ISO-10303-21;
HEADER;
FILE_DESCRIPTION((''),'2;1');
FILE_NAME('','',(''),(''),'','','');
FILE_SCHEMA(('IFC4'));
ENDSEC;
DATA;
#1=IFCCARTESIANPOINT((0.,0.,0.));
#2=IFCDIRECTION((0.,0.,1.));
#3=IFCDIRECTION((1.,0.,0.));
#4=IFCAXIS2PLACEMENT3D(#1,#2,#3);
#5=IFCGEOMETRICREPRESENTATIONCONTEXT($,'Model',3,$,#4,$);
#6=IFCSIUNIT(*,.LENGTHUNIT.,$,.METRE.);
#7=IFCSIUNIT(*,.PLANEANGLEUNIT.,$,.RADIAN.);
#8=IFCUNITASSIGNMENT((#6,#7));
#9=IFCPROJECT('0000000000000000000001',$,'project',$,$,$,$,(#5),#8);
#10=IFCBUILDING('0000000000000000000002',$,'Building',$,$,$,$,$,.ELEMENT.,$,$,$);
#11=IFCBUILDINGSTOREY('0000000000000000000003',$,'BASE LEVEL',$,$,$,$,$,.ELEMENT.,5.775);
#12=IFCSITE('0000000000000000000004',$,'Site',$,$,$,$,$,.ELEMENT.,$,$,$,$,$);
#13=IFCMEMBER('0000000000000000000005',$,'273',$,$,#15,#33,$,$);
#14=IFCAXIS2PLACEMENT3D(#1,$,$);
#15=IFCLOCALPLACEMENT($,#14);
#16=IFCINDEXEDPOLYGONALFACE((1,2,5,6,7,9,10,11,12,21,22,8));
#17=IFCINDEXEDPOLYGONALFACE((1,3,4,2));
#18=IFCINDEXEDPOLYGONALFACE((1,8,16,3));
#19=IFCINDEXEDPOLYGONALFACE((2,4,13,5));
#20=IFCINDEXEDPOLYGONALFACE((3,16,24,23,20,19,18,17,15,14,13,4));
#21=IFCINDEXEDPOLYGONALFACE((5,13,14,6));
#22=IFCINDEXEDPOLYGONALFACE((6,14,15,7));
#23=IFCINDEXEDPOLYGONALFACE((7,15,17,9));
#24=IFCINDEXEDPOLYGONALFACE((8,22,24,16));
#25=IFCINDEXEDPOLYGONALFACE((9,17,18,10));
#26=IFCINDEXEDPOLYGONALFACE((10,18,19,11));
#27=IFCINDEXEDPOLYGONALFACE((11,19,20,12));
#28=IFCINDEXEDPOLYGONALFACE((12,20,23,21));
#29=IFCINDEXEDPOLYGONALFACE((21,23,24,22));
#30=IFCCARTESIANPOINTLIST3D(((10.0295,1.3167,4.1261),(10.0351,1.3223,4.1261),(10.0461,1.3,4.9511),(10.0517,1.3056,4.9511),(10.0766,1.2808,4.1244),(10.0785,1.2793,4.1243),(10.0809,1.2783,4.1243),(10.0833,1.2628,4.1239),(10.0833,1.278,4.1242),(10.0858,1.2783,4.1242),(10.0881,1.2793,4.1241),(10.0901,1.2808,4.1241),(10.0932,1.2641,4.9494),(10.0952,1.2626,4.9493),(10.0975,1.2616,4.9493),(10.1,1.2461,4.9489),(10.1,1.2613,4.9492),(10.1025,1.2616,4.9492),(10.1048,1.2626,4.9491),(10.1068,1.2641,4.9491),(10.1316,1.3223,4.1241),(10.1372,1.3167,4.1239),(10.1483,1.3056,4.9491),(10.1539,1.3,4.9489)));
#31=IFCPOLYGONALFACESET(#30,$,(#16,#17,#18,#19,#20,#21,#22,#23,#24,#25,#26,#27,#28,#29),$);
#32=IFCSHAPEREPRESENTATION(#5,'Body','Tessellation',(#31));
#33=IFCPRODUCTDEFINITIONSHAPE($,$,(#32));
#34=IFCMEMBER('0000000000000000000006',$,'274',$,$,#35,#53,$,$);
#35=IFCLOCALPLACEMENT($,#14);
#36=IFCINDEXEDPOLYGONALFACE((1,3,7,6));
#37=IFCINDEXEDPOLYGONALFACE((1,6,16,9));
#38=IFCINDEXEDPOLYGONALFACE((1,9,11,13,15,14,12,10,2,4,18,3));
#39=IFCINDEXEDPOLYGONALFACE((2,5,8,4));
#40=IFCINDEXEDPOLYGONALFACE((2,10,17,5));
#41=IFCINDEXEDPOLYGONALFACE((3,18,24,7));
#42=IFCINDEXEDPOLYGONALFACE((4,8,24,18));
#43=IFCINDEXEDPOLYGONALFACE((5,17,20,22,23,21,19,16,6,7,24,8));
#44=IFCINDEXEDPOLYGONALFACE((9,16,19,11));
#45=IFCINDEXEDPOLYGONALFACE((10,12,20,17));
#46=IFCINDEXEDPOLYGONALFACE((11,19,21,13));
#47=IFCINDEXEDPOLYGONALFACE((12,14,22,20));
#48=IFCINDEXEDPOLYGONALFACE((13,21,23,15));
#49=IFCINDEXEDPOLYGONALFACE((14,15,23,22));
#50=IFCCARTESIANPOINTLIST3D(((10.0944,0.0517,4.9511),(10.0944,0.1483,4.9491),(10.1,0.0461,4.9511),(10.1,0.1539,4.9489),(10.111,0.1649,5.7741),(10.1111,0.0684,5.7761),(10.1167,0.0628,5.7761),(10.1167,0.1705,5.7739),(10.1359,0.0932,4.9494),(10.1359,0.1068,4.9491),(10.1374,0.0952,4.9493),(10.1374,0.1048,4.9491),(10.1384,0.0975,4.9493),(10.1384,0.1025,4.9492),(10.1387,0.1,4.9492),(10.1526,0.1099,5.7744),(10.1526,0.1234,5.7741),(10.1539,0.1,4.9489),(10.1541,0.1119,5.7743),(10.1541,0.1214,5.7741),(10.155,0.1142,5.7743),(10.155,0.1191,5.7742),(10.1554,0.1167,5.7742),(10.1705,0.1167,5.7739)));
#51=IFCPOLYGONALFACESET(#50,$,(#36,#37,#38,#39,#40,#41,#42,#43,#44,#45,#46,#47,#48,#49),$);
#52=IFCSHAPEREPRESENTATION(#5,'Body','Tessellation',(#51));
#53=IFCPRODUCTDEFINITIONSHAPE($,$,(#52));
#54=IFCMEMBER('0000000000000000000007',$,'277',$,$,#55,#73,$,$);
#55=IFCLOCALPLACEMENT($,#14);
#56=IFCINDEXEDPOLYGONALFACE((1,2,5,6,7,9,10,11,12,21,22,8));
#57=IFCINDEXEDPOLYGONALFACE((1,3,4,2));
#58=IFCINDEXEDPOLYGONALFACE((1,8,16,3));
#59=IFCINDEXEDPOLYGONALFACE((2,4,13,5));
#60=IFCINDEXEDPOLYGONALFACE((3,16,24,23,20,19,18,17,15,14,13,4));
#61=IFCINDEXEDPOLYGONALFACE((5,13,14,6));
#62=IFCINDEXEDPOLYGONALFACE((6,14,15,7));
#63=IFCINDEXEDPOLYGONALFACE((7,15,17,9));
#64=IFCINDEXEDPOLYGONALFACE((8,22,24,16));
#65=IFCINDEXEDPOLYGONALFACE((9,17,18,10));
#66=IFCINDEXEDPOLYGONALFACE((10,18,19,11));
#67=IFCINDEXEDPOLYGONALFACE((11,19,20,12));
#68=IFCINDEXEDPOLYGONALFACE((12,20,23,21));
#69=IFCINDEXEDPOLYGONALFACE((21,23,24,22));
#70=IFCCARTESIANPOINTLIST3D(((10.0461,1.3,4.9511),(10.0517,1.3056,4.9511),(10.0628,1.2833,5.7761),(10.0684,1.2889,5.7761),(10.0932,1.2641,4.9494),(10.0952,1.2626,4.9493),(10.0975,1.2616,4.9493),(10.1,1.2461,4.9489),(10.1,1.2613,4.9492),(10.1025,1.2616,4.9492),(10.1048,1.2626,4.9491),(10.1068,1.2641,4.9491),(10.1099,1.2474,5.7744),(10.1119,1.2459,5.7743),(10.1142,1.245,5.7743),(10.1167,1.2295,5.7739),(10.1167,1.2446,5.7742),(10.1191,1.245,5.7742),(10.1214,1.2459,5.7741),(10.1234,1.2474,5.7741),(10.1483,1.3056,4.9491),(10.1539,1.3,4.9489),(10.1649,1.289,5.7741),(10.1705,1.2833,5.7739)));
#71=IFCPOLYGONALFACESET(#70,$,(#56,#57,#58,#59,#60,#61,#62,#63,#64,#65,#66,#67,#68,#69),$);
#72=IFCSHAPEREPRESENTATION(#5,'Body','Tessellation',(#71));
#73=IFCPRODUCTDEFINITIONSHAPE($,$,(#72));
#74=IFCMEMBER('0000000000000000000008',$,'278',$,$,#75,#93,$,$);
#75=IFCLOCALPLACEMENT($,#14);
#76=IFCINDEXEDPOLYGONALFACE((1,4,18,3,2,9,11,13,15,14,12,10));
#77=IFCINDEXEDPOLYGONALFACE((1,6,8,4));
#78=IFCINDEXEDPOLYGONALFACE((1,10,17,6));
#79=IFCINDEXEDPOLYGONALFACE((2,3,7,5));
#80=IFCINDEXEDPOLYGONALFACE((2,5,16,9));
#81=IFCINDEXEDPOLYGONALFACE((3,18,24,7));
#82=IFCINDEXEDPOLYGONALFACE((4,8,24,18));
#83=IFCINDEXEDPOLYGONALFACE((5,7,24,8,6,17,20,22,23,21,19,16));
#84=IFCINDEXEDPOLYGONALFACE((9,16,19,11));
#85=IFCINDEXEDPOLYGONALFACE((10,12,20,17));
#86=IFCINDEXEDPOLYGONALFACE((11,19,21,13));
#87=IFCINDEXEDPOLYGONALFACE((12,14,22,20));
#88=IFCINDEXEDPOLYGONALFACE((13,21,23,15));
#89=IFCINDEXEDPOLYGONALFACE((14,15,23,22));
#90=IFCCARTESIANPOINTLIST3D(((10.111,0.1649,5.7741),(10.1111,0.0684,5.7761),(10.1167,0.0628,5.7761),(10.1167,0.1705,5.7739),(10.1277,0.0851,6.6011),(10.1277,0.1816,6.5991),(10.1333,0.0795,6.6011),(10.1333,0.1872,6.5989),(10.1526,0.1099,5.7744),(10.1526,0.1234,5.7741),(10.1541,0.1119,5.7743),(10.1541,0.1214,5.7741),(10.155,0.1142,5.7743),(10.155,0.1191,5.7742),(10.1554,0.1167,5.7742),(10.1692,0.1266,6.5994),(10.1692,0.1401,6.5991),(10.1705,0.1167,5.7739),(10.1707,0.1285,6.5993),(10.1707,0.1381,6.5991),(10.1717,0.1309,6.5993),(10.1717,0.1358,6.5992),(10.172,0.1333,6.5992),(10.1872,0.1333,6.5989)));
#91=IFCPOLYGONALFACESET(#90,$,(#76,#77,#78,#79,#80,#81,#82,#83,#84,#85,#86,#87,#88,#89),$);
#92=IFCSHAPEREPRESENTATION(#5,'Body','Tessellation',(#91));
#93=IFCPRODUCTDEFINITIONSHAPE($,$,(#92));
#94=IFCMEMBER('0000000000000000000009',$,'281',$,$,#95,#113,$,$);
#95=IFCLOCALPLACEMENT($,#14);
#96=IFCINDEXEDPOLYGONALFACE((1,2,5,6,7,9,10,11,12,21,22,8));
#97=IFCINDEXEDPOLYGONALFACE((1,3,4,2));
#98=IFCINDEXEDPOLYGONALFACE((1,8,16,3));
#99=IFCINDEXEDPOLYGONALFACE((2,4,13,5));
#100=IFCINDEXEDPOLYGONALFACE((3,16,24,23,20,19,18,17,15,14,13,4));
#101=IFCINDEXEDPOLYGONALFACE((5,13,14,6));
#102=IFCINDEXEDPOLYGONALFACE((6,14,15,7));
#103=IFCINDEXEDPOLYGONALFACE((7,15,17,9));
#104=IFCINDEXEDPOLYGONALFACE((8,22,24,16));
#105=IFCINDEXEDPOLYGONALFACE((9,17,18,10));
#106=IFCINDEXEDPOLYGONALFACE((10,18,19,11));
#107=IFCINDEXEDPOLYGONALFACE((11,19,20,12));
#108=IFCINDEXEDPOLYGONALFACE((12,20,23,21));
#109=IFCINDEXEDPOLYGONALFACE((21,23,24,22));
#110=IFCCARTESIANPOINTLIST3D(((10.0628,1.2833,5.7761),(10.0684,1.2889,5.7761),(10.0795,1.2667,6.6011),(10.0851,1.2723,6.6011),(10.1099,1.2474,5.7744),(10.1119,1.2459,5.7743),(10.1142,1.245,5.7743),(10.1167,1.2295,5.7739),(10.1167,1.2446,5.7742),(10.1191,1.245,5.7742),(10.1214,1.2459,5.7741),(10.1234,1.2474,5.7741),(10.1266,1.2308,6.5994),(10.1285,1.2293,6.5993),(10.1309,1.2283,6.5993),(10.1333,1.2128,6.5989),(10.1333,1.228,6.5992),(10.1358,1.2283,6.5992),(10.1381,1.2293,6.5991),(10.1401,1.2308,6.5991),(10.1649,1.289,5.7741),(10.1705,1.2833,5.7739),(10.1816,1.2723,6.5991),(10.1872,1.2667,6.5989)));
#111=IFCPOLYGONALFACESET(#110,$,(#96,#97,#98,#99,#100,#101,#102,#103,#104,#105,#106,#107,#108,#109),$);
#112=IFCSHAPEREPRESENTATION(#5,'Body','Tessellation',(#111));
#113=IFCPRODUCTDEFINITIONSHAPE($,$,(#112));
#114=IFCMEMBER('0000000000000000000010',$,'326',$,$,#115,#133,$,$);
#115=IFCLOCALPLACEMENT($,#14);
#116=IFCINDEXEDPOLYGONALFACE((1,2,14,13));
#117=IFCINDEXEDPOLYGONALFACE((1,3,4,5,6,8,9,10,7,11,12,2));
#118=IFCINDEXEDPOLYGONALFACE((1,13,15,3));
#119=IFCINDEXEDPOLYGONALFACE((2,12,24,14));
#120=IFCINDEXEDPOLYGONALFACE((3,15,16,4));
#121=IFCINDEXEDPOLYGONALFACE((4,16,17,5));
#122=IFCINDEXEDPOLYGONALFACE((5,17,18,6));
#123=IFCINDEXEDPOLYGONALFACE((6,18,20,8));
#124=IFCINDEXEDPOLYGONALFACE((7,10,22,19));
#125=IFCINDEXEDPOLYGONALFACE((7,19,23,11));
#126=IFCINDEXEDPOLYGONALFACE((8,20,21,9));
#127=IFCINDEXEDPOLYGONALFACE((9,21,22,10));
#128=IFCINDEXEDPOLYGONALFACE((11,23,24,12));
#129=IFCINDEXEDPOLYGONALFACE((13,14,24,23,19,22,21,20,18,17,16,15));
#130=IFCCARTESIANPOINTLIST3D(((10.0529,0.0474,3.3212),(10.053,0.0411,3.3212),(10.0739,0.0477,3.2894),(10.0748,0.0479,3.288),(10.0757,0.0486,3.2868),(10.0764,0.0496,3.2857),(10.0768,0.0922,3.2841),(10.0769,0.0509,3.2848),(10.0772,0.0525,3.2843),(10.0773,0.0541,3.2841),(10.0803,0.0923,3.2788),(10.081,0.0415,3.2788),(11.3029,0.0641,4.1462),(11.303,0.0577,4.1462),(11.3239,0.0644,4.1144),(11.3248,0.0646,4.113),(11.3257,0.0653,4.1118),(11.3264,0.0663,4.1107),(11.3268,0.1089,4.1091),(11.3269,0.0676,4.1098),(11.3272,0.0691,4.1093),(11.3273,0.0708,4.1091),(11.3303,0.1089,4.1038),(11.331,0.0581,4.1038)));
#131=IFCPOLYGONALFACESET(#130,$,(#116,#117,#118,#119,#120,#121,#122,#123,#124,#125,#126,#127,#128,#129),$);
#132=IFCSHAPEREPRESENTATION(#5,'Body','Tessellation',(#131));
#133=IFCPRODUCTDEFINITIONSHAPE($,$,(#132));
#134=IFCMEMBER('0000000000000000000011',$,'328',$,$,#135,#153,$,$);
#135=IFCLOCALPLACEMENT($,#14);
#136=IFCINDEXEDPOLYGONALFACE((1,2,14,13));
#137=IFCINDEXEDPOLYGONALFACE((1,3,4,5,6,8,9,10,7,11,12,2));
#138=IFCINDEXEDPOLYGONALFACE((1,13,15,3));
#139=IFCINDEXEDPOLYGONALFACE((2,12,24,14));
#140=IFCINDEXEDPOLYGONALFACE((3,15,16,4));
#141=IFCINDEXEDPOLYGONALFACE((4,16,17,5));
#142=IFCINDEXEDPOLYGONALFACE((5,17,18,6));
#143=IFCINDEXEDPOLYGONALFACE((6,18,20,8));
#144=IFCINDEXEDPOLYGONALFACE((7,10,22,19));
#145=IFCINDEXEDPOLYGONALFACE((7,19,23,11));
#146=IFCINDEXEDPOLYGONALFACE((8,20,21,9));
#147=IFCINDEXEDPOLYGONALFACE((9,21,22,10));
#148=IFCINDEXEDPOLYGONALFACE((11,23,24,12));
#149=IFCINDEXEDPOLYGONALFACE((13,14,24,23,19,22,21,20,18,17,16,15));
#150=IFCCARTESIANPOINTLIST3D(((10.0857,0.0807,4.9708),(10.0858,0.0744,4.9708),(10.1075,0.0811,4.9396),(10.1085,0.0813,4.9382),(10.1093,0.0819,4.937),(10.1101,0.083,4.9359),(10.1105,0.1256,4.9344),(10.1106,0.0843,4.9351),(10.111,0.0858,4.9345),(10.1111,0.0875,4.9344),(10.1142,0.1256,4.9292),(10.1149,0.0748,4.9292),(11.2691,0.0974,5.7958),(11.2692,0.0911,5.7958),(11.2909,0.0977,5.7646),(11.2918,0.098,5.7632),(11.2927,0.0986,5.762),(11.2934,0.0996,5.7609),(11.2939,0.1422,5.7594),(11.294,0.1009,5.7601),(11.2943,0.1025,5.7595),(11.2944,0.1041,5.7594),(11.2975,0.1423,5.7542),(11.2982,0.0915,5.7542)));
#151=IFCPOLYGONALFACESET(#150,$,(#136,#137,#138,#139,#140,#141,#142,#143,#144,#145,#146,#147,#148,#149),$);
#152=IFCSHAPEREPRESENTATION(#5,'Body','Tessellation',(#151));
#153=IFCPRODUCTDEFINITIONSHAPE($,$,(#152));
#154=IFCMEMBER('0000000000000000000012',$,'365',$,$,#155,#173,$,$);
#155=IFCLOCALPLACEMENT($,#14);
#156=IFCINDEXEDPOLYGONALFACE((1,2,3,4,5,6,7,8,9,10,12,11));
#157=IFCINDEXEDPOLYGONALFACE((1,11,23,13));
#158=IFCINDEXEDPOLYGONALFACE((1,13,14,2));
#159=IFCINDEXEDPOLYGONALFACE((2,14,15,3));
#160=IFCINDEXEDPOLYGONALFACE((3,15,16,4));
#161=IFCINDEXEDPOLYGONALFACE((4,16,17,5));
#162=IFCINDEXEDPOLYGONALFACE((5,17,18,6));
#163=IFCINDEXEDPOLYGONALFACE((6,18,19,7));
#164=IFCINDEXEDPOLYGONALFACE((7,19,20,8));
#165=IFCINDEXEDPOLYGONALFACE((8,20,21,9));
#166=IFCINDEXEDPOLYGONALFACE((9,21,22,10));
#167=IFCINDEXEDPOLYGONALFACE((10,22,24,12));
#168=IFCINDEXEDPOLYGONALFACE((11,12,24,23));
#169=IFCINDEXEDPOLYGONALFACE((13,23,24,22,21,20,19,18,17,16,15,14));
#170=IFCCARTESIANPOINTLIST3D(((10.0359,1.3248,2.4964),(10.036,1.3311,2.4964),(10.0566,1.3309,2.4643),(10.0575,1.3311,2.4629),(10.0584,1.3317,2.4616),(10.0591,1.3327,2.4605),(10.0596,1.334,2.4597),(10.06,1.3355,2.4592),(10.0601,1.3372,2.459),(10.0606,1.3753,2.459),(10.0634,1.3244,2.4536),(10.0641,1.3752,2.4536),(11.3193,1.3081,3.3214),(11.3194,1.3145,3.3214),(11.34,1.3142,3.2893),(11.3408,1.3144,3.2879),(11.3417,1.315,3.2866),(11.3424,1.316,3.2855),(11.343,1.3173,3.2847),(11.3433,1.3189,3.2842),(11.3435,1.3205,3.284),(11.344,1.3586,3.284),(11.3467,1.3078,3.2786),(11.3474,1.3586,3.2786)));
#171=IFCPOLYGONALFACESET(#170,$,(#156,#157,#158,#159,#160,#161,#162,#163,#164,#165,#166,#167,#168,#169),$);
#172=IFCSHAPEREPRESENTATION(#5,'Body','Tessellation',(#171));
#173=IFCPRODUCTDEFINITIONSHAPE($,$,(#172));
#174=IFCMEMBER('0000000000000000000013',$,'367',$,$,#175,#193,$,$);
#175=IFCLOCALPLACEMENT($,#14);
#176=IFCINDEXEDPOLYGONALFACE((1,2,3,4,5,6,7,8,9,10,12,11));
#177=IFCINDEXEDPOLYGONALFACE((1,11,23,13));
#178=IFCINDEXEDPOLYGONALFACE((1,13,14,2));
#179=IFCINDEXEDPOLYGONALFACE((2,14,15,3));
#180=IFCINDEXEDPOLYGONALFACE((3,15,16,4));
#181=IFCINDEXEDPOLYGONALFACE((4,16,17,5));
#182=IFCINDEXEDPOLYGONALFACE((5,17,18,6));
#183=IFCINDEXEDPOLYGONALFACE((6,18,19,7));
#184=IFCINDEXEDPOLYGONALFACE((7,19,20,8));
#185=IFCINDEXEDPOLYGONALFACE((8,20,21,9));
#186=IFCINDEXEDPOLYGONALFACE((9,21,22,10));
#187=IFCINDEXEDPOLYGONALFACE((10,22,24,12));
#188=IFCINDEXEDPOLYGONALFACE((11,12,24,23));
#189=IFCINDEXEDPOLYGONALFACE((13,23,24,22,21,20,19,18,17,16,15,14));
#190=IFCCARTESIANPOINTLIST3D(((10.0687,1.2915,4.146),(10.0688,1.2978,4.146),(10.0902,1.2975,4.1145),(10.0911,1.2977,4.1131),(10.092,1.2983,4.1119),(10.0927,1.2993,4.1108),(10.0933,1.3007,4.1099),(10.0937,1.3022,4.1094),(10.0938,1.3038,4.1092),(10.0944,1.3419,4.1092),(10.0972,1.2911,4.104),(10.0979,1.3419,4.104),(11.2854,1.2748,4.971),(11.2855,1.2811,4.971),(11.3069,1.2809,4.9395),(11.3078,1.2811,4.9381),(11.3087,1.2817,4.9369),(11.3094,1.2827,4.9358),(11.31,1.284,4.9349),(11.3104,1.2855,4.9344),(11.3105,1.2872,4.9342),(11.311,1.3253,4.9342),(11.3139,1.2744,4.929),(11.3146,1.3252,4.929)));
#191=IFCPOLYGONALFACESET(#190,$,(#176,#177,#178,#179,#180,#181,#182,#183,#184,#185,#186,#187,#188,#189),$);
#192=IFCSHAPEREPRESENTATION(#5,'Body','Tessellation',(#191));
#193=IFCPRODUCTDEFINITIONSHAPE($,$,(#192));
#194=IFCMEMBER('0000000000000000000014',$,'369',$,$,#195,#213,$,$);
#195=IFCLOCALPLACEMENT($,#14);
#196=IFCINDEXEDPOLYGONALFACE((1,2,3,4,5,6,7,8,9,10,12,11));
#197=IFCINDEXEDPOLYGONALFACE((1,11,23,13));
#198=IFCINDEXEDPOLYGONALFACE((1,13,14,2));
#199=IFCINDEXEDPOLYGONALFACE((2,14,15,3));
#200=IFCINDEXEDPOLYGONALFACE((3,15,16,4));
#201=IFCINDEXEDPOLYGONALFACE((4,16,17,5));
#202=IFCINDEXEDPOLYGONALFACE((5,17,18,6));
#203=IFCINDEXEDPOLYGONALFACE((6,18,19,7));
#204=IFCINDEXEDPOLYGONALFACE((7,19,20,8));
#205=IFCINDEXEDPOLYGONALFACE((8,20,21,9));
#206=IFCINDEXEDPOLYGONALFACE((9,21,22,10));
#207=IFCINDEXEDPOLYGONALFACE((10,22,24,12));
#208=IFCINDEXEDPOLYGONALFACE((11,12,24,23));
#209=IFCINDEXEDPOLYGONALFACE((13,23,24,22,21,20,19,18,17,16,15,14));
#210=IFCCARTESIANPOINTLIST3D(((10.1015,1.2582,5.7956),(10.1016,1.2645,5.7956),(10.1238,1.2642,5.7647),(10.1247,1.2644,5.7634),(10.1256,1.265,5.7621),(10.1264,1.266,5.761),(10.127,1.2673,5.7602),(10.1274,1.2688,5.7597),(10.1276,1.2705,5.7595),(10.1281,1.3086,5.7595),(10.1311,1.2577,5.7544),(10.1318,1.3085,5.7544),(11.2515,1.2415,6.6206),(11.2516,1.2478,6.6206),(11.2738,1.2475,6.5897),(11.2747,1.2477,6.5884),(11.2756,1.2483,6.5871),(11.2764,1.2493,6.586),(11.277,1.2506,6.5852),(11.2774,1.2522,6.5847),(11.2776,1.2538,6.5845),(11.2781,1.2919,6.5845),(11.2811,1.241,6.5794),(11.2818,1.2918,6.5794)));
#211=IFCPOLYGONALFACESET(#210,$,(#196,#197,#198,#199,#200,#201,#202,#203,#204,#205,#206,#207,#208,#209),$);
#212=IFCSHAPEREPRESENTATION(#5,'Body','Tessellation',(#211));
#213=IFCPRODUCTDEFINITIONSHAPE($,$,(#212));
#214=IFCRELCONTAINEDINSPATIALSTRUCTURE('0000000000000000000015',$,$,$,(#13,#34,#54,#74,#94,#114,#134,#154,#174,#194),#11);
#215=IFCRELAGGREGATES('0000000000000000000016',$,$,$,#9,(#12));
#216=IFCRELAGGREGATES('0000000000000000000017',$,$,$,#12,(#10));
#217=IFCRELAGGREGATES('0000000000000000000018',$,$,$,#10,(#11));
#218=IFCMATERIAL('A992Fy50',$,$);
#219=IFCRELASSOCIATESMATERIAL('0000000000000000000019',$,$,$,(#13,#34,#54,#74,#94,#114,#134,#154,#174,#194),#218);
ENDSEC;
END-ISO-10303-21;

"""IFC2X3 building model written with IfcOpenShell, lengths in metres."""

from ifc_helpers import new_model, si_unit, frame, origin_with_axes, origin_2d_with_axis, place, context, project, spatial, l_section, extrude, material, element, save


model = new_model("IFC2X3")

# Units and contexts
model_context = context("Model", 3, world=origin_with_axes())
ifc_project = project(units=[si_unit("LENGTHUNIT", "METRE"), si_unit("PLANEANGLEUNIT", "RADIAN")], contexts=[model_context])

# Site, building, storey
site = spatial("IfcSite", under=ifc_project, Name="Site", CompositionType="ELEMENT")
building = spatial("IfcBuilding", under=site, Name="Building", CompositionType="ELEMENT")
storey = spatial("IfcBuildingStorey", under=building, Name="BASE LEVEL", CompositionType="ELEMENT", Elevation=5.775)

# Shared definitions
ifc_material = material(Name="A992Fy50")

# Members
for number, where, z_axis, x_axis, name in (
    (1, (10.0833, 1.3167, 4.125), (0.020194, -0.020194, 0.999592), (0.707107, 0.707107, 0.0), "273"),
    (2, (10.1, 0.1, 4.95), (0.020194, 0.020194, 0.999592), (-0.707107, 0.707107, 0.0), "274"),
    (3, (10.1, 1.3, 4.95), (0.020194, -0.020194, 0.999592), (0.707107, 0.707107, 0.0), "277"),
    (4, (10.1167, 0.1167, 5.775), (0.020194, 0.020194, 0.999592), (-0.707107, 0.707107, 0.0), "278"),
    (5, (10.1167, 1.2833, 5.775), (0.020194, -0.020194, 0.999592), (0.707107, 0.707107, 0.0), "281"),
):
    element("IfcMember", number, at=place(None, frame(where, z_axis=z_axis, x_axis=x_axis)), inside=storey, material=ifc_material, Name=name, context=model_context, shape_type="SweptSolid", body=[
        extrude(l_section(Depth=0.0762, Width=0.0762, Thickness=0.0079, FilletRadius=0.0096, at=origin_2d_with_axis()), origin_with_axes(), (0.0, 0.0, 1.0), 0.8253),
    ])
member_1_placement = place(None, frame((10.0667, 0.0667, 3.3), z_axis=(0.834558, 0.011127, 0.550808), x_axis=(-0.013332, 0.999911, 0.0)))
element("IfcMember", 6, at=member_1_placement, inside=storey, material=ifc_material, Name="326", context=model_context, shape_type="SweptSolid", body=[
    extrude(l_section(Depth=0.0508, Width=0.0508, Thickness=0.0063, FilletRadius=0.0063, at=origin_2d_with_axis()), origin_with_axes(), (0.0, 0.0, 1.0), 1.4978),
])
member_2_placement = place(None, frame((10.1, 0.1, 4.95), z_axis=(0.820261, 0.011553, 0.571872), x_axis=(-0.014083, 0.999901, 0.0)))
element("IfcMember", 7, at=member_2_placement, inside=storey, material=ifc_material, Name="328", context=model_context, shape_type="SweptSolid", body=[
    extrude(l_section(Depth=0.0508, Width=0.0508, Thickness=0.0063, FilletRadius=0.0063, at=origin_2d_with_axis()), origin_with_axes(), (0.0, 0.0, 1.0), 1.4426),
])
member_3_placement = place(None, frame((10.05, 1.35, 2.475), z_axis=(0.841128, -0.010924, 0.540725), x_axis=(0.012345, 0.999924, 0.0)))
element("IfcMember", 8, at=member_3_placement, inside=storey, material=ifc_material, Name="365", context=model_context, shape_type="SweptSolid", body=[
    extrude(l_section(Depth=0.0508, Width=0.0508, Thickness=0.0063, FilletRadius=0.0063, at=origin_2d_with_axis()), origin_with_axes(), (0.0, 0.0, 1.0), 1.5257),
])
member_4_placement = place(None, frame((10.0833, 1.3167, 4.125), z_axis=(0.827611, -0.011337, 0.561188), x_axis=(0.013697, 0.999906, 0.0)))
element("IfcMember", 9, at=member_4_placement, inside=storey, material=ifc_material, Name="367", context=model_context, shape_type="SweptSolid", body=[
    extrude(l_section(Depth=0.0508, Width=0.0508, Thickness=0.0063, FilletRadius=0.0063, at=origin_2d_with_axis()), origin_with_axes(), (0.0, 0.0, 1.0), 1.4701),
])
member_5_placement = place(None, frame((10.1167, 1.2833, 5.775), z_axis=(0.812482, -0.011775, 0.582867), x_axis=(0.015383, 0.999882, 0.0)))
element("IfcMember", 10, at=member_5_placement, inside=storey, material=ifc_material, Name="369", context=model_context, shape_type="SweptSolid", body=[
    extrude(l_section(Depth=0.0508, Width=0.0508, Thickness=0.0063, FilletRadius=0.0063, at=origin_2d_with_axis()), origin_with_axes(), (0.0, 0.0, 1.0), 1.4154),
])

save(model, "model.ifc")
